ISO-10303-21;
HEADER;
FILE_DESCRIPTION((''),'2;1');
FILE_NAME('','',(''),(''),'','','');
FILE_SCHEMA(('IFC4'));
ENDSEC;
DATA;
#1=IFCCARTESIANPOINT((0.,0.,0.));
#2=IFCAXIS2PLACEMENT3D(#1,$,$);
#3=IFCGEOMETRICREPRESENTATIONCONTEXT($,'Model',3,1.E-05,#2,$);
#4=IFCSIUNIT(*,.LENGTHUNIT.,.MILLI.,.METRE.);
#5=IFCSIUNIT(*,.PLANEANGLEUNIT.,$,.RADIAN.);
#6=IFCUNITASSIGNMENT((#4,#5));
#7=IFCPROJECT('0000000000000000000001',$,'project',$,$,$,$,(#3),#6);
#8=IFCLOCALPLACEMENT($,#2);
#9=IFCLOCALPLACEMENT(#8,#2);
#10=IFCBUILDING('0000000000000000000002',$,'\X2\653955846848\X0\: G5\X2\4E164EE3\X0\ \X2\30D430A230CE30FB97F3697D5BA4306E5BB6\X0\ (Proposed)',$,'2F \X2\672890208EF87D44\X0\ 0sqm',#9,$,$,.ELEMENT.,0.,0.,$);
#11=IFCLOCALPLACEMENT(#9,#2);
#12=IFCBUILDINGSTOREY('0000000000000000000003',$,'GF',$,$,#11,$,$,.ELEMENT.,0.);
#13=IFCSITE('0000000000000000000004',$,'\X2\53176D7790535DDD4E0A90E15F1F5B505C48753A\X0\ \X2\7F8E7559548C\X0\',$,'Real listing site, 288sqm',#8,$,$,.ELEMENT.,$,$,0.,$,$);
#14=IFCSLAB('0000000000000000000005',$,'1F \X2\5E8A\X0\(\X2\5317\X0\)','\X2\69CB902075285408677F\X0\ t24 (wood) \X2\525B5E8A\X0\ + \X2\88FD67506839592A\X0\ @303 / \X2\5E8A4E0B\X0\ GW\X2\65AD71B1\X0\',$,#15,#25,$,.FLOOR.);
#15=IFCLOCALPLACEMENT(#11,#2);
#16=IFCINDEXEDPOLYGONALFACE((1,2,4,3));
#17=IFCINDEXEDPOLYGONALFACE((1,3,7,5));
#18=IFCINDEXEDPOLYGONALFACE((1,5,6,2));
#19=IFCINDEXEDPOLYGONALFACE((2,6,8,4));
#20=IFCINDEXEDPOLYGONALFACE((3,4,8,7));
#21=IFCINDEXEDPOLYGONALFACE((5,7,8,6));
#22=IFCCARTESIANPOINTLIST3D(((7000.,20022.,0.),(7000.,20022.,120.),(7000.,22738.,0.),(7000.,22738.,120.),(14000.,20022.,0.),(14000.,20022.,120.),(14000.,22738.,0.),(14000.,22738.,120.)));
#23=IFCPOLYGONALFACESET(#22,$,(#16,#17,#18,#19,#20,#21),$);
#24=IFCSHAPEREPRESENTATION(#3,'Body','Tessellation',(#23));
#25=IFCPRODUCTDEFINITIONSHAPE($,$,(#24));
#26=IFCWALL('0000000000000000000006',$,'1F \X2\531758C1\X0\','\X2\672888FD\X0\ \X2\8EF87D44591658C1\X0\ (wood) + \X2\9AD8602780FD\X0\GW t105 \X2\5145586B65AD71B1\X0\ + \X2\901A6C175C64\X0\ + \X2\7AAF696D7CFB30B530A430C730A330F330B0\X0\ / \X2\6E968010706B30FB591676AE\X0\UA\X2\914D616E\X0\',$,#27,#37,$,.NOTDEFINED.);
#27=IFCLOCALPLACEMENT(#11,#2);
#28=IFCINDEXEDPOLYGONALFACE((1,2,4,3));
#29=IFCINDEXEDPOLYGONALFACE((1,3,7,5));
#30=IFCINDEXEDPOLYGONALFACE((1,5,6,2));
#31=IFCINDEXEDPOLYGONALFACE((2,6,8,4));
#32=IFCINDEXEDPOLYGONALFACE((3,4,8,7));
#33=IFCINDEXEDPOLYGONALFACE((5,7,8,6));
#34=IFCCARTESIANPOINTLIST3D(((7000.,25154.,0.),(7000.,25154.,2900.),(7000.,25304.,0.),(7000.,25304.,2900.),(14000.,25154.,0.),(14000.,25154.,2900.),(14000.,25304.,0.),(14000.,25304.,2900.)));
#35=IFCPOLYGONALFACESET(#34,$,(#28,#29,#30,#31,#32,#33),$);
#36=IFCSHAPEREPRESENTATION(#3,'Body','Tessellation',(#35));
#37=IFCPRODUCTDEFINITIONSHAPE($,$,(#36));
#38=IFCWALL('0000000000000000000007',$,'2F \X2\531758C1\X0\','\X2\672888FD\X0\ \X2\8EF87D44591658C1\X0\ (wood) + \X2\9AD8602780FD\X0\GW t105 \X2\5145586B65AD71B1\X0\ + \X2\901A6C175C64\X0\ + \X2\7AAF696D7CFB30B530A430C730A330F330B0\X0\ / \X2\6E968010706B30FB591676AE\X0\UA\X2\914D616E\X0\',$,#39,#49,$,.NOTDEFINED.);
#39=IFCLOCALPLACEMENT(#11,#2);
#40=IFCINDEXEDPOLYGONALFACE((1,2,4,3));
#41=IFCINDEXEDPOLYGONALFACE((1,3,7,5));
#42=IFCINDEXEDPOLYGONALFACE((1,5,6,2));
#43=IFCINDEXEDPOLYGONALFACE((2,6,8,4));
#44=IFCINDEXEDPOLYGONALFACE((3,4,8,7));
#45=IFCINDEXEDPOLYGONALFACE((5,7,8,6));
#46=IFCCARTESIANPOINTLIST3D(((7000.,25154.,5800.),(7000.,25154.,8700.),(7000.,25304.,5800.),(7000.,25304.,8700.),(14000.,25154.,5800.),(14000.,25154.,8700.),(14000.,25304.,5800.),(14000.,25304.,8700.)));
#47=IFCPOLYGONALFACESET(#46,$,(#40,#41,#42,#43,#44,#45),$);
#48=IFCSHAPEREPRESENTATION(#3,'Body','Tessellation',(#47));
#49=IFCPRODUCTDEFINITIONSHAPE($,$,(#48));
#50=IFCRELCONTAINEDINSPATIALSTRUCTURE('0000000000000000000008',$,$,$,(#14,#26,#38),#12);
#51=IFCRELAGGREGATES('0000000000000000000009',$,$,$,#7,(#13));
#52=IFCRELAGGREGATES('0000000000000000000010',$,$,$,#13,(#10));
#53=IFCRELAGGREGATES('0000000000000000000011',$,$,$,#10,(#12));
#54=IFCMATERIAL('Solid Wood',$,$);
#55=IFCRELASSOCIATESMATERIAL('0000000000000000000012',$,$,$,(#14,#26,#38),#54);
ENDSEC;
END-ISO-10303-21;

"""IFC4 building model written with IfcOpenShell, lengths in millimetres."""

from ifc_helpers import new_model, si_unit, frame, frame_2d, origin, place, context, project, spatial, rectangle, extrude, material, element, save


model = new_model("IFC4")

# Units and contexts
model_context = context("Model", 3, precision=1e-05, world=origin())
ifc_project = project(units=[si_unit("LENGTHUNIT", "METRE", prefix="MILLI"), si_unit("PLANEANGLEUNIT", "RADIAN")], contexts=[model_context])

# Site, building, storey
site_placement = place(None, origin())
site = spatial("IfcSite", under=ifc_project, at=site_placement, Name="北海道川上郡弟子屈町 美留和", ObjectType="Real listing site, 288sqm", CompositionType="ELEMENT", RefElevation=0.0)
building_placement = place(site_placement, origin())
building = spatial("IfcBuilding", under=site, at=building_placement, Name="改善案: G5世代 ピアノ・音楽室の家 (Proposed)", ObjectType="2F 木造軸組 0sqm", CompositionType="ELEMENT", ElevationOfRefHeight=0.0, ElevationOfTerrain=0.0)
storey_placement = place(building_placement, origin())
storey = spatial("IfcBuildingStorey", under=building, at=storey_placement, Name="GF", CompositionType="ELEMENT", Elevation=0.0)

# Slab
ifc_material_1 = material(Name="Solid Wood")
slab_1_placement = place(storey_placement, frame((3500.0, 10011.0, 0.0)))
element("IfcSlab", 1, at=slab_1_placement, inside=storey, material=ifc_material_1, Name="1F 床(北)", Description="構造用合板 t24 (wood) 剛床 + 製材根太 @303 / 床下 GW断熱", PredefinedType="FLOOR", context=model_context, shape_type="SweptSolid", body=[
    extrude(rectangle(XDim=7000.0, YDim=2716.0, at=frame_2d((3500.0, 1358.0))), frame((3500.0, 10011.0, 0.0)), (0.0, 0.0, 1.0), 120.0),
])

# Wall
wall_1_placement = place(storey_placement, frame((3500.0, 12577.0, 0.0)))
element("IfcWall", 2, at=wall_1_placement, inside=storey, material=ifc_material_1, Name="1F 北壁", Description="木製 軸組外壁 (wood) + 高性能GW t105 充填断熱 + 通気層 + 窯業系サイディング / 準耐火・外皮UA配慮", PredefinedType="NOTDEFINED", context=model_context, shape_type="SweptSolid", body=[
    extrude(rectangle(XDim=7000.0, YDim=150.0, at=frame_2d((3500.0, 75.0))), frame((3500.0, 12577.0, 0.0)), (0.0, 0.0, 1.0), 2900.0),
])

# Wall
wall_2_placement = place(storey_placement, frame((3500.0, 12577.0, 2900.0)))
element("IfcWall", 3, at=wall_2_placement, inside=storey, material=ifc_material_1, Name="2F 北壁", Description="木製 軸組外壁 (wood) + 高性能GW t105 充填断熱 + 通気層 + 窯業系サイディング / 準耐火・外皮UA配慮", PredefinedType="NOTDEFINED", context=model_context, shape_type="SweptSolid", body=[
    extrude(rectangle(XDim=7000.0, YDim=150.0, at=frame_2d((3500.0, 75.0))), frame((3500.0, 12577.0, 2900.0)), (0.0, 0.0, 1.0), 2900.0),
])

save(model, "model.ifc")
